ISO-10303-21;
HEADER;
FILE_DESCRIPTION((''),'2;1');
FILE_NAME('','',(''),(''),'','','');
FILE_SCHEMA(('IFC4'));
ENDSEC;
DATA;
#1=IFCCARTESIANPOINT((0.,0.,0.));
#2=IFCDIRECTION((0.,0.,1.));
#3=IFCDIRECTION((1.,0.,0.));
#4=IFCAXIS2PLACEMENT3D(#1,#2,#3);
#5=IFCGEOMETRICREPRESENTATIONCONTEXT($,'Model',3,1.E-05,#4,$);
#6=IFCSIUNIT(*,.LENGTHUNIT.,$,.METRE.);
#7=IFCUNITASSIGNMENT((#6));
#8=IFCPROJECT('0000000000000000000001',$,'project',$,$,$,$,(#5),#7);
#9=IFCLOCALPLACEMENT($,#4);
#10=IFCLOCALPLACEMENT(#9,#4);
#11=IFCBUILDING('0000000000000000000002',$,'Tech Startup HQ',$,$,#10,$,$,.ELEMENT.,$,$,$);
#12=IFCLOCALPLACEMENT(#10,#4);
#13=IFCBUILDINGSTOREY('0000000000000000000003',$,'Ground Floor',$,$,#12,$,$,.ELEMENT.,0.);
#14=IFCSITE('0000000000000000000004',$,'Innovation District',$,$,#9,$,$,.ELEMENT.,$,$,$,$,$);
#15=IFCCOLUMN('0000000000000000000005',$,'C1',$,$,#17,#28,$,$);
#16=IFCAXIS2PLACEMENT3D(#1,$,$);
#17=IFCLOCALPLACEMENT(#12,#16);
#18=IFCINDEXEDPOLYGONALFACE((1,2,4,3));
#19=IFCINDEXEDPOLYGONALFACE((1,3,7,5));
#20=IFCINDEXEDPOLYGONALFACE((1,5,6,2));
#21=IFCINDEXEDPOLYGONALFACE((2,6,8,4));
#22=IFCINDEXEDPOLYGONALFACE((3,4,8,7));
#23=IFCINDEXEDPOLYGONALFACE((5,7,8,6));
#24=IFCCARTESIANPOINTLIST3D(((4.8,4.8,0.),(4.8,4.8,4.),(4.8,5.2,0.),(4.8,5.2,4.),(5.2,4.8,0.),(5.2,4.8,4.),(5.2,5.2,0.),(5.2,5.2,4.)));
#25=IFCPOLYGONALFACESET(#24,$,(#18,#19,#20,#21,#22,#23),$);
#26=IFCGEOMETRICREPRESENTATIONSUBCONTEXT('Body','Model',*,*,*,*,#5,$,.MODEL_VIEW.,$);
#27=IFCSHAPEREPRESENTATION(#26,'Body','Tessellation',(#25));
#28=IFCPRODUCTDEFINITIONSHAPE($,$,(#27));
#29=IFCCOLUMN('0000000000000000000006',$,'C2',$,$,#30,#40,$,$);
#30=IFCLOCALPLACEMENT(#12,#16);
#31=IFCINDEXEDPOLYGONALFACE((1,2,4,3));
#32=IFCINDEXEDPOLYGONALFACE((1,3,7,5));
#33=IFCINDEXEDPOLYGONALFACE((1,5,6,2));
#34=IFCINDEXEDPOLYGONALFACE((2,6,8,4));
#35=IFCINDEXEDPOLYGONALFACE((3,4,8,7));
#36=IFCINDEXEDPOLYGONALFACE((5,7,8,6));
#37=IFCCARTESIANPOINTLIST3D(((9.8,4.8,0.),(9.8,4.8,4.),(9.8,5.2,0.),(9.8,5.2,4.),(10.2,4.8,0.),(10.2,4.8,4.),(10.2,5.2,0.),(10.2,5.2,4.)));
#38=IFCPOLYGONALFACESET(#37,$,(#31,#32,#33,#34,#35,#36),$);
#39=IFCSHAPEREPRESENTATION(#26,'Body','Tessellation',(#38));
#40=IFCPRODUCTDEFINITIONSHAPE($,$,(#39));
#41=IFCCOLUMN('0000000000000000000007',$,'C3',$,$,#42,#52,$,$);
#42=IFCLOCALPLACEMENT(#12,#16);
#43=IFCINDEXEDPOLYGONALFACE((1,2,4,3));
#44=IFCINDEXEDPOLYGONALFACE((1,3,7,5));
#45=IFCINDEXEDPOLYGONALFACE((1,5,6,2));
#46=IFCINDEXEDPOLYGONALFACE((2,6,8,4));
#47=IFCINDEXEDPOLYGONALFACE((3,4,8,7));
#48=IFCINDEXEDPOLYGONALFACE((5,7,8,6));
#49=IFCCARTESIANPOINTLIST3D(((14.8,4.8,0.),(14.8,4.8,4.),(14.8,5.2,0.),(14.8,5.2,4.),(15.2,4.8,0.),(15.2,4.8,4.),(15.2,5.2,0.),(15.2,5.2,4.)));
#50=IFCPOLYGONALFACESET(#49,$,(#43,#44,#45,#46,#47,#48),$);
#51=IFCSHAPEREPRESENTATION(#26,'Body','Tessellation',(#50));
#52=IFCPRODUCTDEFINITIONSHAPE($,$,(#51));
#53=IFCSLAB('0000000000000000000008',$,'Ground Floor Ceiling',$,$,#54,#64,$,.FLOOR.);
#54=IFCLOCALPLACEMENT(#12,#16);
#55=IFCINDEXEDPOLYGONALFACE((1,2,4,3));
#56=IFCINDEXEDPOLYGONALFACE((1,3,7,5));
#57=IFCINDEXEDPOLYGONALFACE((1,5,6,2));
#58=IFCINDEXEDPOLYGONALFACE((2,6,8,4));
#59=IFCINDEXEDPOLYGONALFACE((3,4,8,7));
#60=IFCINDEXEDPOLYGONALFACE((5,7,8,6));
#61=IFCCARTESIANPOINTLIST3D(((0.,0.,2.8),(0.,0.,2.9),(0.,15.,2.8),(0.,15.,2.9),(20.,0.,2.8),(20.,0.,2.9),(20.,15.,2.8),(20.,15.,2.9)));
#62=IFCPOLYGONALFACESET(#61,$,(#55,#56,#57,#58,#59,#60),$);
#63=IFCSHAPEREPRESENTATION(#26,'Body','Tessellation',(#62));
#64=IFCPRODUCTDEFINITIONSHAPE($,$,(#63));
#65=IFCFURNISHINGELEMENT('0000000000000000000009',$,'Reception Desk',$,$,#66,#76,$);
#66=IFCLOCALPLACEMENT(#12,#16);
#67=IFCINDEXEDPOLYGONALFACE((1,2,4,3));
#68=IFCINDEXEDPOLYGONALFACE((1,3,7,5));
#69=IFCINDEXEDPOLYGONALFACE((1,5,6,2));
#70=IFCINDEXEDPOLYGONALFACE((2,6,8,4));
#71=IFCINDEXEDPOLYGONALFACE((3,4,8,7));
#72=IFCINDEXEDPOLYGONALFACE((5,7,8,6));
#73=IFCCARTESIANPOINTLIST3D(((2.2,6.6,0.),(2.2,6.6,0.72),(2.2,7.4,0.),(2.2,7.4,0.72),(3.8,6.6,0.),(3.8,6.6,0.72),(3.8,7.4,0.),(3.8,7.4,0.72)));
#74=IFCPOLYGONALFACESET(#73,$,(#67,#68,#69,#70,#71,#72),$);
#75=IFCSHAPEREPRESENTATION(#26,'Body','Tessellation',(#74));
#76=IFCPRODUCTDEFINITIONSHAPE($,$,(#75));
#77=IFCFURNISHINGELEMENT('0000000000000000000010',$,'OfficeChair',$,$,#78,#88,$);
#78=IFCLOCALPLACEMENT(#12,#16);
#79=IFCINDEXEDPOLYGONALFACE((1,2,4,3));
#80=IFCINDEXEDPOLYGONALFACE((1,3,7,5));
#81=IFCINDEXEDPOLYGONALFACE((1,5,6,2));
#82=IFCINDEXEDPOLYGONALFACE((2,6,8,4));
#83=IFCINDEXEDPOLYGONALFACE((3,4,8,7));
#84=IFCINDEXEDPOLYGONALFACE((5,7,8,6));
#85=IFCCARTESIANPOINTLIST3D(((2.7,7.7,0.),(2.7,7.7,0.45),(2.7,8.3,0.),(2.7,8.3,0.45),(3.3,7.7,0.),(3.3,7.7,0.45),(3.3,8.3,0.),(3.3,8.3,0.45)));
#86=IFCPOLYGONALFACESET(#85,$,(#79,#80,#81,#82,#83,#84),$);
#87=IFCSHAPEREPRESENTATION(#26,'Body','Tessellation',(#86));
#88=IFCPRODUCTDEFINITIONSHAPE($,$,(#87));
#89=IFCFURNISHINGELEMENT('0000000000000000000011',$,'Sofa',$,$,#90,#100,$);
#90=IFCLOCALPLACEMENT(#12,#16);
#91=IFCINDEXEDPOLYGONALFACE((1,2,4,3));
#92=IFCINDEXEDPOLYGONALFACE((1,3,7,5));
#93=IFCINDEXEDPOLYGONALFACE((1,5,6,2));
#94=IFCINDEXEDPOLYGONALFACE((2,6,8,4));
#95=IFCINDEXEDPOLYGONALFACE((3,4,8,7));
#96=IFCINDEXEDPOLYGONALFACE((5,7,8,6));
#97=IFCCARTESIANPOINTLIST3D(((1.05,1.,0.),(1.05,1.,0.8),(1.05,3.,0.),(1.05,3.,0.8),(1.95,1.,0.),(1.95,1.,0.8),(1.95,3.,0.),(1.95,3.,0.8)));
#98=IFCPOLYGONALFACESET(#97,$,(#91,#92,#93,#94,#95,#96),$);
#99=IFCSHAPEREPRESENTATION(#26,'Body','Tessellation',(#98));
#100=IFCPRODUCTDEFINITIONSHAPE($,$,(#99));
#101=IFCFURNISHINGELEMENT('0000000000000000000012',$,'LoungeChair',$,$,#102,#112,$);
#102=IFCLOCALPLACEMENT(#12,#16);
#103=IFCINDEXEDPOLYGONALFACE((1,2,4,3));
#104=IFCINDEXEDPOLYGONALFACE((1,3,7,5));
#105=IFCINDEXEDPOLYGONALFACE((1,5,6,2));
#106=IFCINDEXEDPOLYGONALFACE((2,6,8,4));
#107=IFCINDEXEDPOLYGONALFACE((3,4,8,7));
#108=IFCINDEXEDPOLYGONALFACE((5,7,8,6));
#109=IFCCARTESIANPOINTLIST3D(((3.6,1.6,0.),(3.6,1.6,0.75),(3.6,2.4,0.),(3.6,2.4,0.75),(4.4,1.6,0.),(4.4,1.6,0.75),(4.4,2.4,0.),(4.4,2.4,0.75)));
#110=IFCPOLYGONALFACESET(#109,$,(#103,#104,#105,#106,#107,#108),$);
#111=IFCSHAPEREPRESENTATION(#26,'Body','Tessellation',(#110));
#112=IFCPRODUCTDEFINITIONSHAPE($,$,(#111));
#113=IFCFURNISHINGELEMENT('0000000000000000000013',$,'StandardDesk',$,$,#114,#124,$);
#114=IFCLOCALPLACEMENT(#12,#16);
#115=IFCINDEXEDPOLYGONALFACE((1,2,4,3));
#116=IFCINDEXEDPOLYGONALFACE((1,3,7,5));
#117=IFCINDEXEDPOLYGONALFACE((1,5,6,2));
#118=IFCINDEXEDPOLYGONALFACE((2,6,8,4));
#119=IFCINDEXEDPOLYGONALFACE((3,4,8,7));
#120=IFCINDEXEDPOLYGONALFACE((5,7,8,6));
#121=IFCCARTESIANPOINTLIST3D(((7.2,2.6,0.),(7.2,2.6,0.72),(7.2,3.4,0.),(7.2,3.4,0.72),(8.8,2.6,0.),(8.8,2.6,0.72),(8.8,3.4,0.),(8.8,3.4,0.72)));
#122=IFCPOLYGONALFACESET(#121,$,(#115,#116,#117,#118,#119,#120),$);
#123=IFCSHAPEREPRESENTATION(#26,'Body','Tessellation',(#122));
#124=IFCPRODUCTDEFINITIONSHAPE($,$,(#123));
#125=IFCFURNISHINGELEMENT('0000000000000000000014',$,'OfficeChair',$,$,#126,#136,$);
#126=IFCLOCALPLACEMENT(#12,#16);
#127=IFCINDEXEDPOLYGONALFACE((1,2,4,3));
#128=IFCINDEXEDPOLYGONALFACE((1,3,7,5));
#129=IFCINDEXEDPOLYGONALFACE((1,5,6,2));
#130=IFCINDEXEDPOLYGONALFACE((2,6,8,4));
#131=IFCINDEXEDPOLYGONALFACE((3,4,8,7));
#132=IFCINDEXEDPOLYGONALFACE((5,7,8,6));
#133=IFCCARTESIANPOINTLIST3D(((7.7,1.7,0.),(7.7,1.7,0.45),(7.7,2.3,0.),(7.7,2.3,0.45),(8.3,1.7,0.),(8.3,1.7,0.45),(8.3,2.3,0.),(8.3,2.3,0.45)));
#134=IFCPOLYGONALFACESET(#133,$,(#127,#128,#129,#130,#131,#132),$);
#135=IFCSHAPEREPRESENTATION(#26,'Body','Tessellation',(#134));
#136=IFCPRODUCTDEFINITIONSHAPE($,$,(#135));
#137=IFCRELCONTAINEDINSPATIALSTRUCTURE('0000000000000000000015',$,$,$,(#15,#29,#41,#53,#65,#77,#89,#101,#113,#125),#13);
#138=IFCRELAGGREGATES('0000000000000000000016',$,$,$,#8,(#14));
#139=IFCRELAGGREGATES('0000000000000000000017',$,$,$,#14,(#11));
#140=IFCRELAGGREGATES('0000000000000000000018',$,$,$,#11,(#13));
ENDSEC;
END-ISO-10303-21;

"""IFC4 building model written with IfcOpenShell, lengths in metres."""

from ifc_helpers import new_model, si_unit, origin_with_axes, place, context, subcontext, project, spatial, polyline, outline, extrude, element, save


model = new_model("IFC4")

# Units and contexts
model_context = context("Model", 3, precision=1e-05, world=origin_with_axes())
body_context = subcontext(model_context, "Body", "Model", "MODEL_VIEW")
ifc_project = project(units=[si_unit("LENGTHUNIT", "METRE")], contexts=[model_context])

# Site, building, storey
site_placement = place(None, origin_with_axes())
site = spatial("IfcSite", under=ifc_project, at=site_placement, Name="Innovation District", CompositionType="ELEMENT")
building_placement = place(site_placement, origin_with_axes())
building = spatial("IfcBuilding", under=site, at=building_placement, Name="Tech Startup HQ", CompositionType="ELEMENT")
storey_placement = place(building_placement, origin_with_axes())
storey = spatial("IfcBuildingStorey", under=building, at=storey_placement, Name="Ground Floor", CompositionType="ELEMENT", Elevation=0.0)

# Columns
column_1_placement = place(storey_placement, origin_with_axes())
element("IfcColumn", 1, at=column_1_placement, inside=storey, Name="C1", context=body_context, shape_type="SweptSolid", body=[
    extrude(outline(polyline([(4.8, 4.8, 0.0), (5.2, 4.8, 0.0), (5.2, 5.2, 0.0), (4.8, 5.2, 0.0), (4.8, 4.8, 0.0)])), None, (0.0, 0.0, 1.0), 4.0),
])
column_2_placement = place(storey_placement, origin_with_axes())
element("IfcColumn", 2, at=column_2_placement, inside=storey, Name="C2", context=body_context, shape_type="SweptSolid", body=[
    extrude(outline(polyline([(9.8, 4.8, 0.0), (10.2, 4.8, 0.0), (10.2, 5.2, 0.0), (9.8, 5.2, 0.0), (9.8, 4.8, 0.0)])), None, (0.0, 0.0, 1.0), 4.0),
])
column_3_placement = place(storey_placement, origin_with_axes())
element("IfcColumn", 3, at=column_3_placement, inside=storey, Name="C3", context=body_context, shape_type="SweptSolid", body=[
    extrude(outline(polyline([(14.8, 4.8, 0.0), (15.2, 4.8, 0.0), (15.2, 5.2, 0.0), (14.8, 5.2, 0.0), (14.8, 4.8, 0.0)])), None, (0.0, 0.0, 1.0), 4.0),
])

# Slab
slab_placement = place(storey_placement, origin_with_axes())
element("IfcSlab", 4, at=slab_placement, inside=storey, Name="Ground Floor Ceiling", PredefinedType="FLOOR", context=body_context, shape_type="SweptSolid", body=[
    extrude(outline(polyline([(0.0, 0.0, 2.8), (20.0, 0.0, 2.8), (20.0, 15.0, 2.8), (0.0, 15.0, 2.8), (0.0, 0.0, 2.8)])), None, (0.0, 0.0, 1.0), 0.1),
])

# Furnishing elements
furnishing_1_placement = place(storey_placement, origin_with_axes())
element("IfcFurnishingElement", 5, at=furnishing_1_placement, inside=storey, Name="Reception Desk", context=body_context, shape_type="SweptSolid", body=[
    extrude(outline(polyline([(3.8, 7.4, 0.0), (2.2, 7.4, 0.0), (2.2, 6.6, 0.0), (3.8, 6.6, 0.0), (3.8, 7.4, 0.0)])), None, (0.0, 0.0, 1.0), 0.72),
])
furnishing_2_placement = place(storey_placement, origin_with_axes())
element("IfcFurnishingElement", 6, at=furnishing_2_placement, inside=storey, Name="OfficeChair", context=body_context, shape_type="SweptSolid", body=[
    extrude(outline(polyline([(3.3, 8.3, 0.0), (2.7, 8.3, 0.0), (2.7, 7.7, 0.0), (3.3, 7.7, 0.0), (3.3, 8.3, 0.0)])), None, (0.0, 0.0, 1.0), 0.45),
])
furnishing_3_placement = place(storey_placement, origin_with_axes())
element("IfcFurnishingElement", 7, at=furnishing_3_placement, inside=storey, Name="Sofa", context=body_context, shape_type="SweptSolid", body=[
    extrude(outline(polyline([(1.05, 3.0, 0.0), (1.05, 1.0, 0.0), (1.95, 1.0, 0.0), (1.95, 3.0, 0.0), (1.05, 3.0, 0.0)])), None, (0.0, 0.0, 1.0), 0.8),
])
furnishing_4_placement = place(storey_placement, origin_with_axes())
element("IfcFurnishingElement", 8, at=furnishing_4_placement, inside=storey, Name="LoungeChair", context=body_context, shape_type="SweptSolid", body=[
    extrude(outline(polyline([(4.4, 1.6, 0.0), (4.4, 2.4, 0.0), (3.6, 2.4, 0.0), (3.6, 1.6, 0.0), (4.4, 1.6, 0.0)])), None, (0.0, 0.0, 1.0), 0.75),
])
furnishing_5_placement = place(storey_placement, origin_with_axes())
element("IfcFurnishingElement", 9, at=furnishing_5_placement, inside=storey, Name="StandardDesk", context=body_context, shape_type="SweptSolid", body=[
    extrude(outline(polyline([(7.2, 2.6, 0.0), (8.8, 2.6, 0.0), (8.8, 3.4, 0.0), (7.2, 3.4, 0.0), (7.2, 2.6, 0.0)])), None, (0.0, 0.0, 1.0), 0.72),
])
furnishing_6_placement = place(storey_placement, origin_with_axes())
element("IfcFurnishingElement", 10, at=furnishing_6_placement, inside=storey, Name="OfficeChair", context=body_context, shape_type="SweptSolid", body=[
    extrude(outline(polyline([(7.7, 1.7, 0.0), (8.3, 1.7, 0.0), (8.3, 2.3, 0.0), (7.7, 2.3, 0.0), (7.7, 1.7, 0.0)])), None, (0.0, 0.0, 1.0), 0.45),
])

save(model, "model.ifc")
